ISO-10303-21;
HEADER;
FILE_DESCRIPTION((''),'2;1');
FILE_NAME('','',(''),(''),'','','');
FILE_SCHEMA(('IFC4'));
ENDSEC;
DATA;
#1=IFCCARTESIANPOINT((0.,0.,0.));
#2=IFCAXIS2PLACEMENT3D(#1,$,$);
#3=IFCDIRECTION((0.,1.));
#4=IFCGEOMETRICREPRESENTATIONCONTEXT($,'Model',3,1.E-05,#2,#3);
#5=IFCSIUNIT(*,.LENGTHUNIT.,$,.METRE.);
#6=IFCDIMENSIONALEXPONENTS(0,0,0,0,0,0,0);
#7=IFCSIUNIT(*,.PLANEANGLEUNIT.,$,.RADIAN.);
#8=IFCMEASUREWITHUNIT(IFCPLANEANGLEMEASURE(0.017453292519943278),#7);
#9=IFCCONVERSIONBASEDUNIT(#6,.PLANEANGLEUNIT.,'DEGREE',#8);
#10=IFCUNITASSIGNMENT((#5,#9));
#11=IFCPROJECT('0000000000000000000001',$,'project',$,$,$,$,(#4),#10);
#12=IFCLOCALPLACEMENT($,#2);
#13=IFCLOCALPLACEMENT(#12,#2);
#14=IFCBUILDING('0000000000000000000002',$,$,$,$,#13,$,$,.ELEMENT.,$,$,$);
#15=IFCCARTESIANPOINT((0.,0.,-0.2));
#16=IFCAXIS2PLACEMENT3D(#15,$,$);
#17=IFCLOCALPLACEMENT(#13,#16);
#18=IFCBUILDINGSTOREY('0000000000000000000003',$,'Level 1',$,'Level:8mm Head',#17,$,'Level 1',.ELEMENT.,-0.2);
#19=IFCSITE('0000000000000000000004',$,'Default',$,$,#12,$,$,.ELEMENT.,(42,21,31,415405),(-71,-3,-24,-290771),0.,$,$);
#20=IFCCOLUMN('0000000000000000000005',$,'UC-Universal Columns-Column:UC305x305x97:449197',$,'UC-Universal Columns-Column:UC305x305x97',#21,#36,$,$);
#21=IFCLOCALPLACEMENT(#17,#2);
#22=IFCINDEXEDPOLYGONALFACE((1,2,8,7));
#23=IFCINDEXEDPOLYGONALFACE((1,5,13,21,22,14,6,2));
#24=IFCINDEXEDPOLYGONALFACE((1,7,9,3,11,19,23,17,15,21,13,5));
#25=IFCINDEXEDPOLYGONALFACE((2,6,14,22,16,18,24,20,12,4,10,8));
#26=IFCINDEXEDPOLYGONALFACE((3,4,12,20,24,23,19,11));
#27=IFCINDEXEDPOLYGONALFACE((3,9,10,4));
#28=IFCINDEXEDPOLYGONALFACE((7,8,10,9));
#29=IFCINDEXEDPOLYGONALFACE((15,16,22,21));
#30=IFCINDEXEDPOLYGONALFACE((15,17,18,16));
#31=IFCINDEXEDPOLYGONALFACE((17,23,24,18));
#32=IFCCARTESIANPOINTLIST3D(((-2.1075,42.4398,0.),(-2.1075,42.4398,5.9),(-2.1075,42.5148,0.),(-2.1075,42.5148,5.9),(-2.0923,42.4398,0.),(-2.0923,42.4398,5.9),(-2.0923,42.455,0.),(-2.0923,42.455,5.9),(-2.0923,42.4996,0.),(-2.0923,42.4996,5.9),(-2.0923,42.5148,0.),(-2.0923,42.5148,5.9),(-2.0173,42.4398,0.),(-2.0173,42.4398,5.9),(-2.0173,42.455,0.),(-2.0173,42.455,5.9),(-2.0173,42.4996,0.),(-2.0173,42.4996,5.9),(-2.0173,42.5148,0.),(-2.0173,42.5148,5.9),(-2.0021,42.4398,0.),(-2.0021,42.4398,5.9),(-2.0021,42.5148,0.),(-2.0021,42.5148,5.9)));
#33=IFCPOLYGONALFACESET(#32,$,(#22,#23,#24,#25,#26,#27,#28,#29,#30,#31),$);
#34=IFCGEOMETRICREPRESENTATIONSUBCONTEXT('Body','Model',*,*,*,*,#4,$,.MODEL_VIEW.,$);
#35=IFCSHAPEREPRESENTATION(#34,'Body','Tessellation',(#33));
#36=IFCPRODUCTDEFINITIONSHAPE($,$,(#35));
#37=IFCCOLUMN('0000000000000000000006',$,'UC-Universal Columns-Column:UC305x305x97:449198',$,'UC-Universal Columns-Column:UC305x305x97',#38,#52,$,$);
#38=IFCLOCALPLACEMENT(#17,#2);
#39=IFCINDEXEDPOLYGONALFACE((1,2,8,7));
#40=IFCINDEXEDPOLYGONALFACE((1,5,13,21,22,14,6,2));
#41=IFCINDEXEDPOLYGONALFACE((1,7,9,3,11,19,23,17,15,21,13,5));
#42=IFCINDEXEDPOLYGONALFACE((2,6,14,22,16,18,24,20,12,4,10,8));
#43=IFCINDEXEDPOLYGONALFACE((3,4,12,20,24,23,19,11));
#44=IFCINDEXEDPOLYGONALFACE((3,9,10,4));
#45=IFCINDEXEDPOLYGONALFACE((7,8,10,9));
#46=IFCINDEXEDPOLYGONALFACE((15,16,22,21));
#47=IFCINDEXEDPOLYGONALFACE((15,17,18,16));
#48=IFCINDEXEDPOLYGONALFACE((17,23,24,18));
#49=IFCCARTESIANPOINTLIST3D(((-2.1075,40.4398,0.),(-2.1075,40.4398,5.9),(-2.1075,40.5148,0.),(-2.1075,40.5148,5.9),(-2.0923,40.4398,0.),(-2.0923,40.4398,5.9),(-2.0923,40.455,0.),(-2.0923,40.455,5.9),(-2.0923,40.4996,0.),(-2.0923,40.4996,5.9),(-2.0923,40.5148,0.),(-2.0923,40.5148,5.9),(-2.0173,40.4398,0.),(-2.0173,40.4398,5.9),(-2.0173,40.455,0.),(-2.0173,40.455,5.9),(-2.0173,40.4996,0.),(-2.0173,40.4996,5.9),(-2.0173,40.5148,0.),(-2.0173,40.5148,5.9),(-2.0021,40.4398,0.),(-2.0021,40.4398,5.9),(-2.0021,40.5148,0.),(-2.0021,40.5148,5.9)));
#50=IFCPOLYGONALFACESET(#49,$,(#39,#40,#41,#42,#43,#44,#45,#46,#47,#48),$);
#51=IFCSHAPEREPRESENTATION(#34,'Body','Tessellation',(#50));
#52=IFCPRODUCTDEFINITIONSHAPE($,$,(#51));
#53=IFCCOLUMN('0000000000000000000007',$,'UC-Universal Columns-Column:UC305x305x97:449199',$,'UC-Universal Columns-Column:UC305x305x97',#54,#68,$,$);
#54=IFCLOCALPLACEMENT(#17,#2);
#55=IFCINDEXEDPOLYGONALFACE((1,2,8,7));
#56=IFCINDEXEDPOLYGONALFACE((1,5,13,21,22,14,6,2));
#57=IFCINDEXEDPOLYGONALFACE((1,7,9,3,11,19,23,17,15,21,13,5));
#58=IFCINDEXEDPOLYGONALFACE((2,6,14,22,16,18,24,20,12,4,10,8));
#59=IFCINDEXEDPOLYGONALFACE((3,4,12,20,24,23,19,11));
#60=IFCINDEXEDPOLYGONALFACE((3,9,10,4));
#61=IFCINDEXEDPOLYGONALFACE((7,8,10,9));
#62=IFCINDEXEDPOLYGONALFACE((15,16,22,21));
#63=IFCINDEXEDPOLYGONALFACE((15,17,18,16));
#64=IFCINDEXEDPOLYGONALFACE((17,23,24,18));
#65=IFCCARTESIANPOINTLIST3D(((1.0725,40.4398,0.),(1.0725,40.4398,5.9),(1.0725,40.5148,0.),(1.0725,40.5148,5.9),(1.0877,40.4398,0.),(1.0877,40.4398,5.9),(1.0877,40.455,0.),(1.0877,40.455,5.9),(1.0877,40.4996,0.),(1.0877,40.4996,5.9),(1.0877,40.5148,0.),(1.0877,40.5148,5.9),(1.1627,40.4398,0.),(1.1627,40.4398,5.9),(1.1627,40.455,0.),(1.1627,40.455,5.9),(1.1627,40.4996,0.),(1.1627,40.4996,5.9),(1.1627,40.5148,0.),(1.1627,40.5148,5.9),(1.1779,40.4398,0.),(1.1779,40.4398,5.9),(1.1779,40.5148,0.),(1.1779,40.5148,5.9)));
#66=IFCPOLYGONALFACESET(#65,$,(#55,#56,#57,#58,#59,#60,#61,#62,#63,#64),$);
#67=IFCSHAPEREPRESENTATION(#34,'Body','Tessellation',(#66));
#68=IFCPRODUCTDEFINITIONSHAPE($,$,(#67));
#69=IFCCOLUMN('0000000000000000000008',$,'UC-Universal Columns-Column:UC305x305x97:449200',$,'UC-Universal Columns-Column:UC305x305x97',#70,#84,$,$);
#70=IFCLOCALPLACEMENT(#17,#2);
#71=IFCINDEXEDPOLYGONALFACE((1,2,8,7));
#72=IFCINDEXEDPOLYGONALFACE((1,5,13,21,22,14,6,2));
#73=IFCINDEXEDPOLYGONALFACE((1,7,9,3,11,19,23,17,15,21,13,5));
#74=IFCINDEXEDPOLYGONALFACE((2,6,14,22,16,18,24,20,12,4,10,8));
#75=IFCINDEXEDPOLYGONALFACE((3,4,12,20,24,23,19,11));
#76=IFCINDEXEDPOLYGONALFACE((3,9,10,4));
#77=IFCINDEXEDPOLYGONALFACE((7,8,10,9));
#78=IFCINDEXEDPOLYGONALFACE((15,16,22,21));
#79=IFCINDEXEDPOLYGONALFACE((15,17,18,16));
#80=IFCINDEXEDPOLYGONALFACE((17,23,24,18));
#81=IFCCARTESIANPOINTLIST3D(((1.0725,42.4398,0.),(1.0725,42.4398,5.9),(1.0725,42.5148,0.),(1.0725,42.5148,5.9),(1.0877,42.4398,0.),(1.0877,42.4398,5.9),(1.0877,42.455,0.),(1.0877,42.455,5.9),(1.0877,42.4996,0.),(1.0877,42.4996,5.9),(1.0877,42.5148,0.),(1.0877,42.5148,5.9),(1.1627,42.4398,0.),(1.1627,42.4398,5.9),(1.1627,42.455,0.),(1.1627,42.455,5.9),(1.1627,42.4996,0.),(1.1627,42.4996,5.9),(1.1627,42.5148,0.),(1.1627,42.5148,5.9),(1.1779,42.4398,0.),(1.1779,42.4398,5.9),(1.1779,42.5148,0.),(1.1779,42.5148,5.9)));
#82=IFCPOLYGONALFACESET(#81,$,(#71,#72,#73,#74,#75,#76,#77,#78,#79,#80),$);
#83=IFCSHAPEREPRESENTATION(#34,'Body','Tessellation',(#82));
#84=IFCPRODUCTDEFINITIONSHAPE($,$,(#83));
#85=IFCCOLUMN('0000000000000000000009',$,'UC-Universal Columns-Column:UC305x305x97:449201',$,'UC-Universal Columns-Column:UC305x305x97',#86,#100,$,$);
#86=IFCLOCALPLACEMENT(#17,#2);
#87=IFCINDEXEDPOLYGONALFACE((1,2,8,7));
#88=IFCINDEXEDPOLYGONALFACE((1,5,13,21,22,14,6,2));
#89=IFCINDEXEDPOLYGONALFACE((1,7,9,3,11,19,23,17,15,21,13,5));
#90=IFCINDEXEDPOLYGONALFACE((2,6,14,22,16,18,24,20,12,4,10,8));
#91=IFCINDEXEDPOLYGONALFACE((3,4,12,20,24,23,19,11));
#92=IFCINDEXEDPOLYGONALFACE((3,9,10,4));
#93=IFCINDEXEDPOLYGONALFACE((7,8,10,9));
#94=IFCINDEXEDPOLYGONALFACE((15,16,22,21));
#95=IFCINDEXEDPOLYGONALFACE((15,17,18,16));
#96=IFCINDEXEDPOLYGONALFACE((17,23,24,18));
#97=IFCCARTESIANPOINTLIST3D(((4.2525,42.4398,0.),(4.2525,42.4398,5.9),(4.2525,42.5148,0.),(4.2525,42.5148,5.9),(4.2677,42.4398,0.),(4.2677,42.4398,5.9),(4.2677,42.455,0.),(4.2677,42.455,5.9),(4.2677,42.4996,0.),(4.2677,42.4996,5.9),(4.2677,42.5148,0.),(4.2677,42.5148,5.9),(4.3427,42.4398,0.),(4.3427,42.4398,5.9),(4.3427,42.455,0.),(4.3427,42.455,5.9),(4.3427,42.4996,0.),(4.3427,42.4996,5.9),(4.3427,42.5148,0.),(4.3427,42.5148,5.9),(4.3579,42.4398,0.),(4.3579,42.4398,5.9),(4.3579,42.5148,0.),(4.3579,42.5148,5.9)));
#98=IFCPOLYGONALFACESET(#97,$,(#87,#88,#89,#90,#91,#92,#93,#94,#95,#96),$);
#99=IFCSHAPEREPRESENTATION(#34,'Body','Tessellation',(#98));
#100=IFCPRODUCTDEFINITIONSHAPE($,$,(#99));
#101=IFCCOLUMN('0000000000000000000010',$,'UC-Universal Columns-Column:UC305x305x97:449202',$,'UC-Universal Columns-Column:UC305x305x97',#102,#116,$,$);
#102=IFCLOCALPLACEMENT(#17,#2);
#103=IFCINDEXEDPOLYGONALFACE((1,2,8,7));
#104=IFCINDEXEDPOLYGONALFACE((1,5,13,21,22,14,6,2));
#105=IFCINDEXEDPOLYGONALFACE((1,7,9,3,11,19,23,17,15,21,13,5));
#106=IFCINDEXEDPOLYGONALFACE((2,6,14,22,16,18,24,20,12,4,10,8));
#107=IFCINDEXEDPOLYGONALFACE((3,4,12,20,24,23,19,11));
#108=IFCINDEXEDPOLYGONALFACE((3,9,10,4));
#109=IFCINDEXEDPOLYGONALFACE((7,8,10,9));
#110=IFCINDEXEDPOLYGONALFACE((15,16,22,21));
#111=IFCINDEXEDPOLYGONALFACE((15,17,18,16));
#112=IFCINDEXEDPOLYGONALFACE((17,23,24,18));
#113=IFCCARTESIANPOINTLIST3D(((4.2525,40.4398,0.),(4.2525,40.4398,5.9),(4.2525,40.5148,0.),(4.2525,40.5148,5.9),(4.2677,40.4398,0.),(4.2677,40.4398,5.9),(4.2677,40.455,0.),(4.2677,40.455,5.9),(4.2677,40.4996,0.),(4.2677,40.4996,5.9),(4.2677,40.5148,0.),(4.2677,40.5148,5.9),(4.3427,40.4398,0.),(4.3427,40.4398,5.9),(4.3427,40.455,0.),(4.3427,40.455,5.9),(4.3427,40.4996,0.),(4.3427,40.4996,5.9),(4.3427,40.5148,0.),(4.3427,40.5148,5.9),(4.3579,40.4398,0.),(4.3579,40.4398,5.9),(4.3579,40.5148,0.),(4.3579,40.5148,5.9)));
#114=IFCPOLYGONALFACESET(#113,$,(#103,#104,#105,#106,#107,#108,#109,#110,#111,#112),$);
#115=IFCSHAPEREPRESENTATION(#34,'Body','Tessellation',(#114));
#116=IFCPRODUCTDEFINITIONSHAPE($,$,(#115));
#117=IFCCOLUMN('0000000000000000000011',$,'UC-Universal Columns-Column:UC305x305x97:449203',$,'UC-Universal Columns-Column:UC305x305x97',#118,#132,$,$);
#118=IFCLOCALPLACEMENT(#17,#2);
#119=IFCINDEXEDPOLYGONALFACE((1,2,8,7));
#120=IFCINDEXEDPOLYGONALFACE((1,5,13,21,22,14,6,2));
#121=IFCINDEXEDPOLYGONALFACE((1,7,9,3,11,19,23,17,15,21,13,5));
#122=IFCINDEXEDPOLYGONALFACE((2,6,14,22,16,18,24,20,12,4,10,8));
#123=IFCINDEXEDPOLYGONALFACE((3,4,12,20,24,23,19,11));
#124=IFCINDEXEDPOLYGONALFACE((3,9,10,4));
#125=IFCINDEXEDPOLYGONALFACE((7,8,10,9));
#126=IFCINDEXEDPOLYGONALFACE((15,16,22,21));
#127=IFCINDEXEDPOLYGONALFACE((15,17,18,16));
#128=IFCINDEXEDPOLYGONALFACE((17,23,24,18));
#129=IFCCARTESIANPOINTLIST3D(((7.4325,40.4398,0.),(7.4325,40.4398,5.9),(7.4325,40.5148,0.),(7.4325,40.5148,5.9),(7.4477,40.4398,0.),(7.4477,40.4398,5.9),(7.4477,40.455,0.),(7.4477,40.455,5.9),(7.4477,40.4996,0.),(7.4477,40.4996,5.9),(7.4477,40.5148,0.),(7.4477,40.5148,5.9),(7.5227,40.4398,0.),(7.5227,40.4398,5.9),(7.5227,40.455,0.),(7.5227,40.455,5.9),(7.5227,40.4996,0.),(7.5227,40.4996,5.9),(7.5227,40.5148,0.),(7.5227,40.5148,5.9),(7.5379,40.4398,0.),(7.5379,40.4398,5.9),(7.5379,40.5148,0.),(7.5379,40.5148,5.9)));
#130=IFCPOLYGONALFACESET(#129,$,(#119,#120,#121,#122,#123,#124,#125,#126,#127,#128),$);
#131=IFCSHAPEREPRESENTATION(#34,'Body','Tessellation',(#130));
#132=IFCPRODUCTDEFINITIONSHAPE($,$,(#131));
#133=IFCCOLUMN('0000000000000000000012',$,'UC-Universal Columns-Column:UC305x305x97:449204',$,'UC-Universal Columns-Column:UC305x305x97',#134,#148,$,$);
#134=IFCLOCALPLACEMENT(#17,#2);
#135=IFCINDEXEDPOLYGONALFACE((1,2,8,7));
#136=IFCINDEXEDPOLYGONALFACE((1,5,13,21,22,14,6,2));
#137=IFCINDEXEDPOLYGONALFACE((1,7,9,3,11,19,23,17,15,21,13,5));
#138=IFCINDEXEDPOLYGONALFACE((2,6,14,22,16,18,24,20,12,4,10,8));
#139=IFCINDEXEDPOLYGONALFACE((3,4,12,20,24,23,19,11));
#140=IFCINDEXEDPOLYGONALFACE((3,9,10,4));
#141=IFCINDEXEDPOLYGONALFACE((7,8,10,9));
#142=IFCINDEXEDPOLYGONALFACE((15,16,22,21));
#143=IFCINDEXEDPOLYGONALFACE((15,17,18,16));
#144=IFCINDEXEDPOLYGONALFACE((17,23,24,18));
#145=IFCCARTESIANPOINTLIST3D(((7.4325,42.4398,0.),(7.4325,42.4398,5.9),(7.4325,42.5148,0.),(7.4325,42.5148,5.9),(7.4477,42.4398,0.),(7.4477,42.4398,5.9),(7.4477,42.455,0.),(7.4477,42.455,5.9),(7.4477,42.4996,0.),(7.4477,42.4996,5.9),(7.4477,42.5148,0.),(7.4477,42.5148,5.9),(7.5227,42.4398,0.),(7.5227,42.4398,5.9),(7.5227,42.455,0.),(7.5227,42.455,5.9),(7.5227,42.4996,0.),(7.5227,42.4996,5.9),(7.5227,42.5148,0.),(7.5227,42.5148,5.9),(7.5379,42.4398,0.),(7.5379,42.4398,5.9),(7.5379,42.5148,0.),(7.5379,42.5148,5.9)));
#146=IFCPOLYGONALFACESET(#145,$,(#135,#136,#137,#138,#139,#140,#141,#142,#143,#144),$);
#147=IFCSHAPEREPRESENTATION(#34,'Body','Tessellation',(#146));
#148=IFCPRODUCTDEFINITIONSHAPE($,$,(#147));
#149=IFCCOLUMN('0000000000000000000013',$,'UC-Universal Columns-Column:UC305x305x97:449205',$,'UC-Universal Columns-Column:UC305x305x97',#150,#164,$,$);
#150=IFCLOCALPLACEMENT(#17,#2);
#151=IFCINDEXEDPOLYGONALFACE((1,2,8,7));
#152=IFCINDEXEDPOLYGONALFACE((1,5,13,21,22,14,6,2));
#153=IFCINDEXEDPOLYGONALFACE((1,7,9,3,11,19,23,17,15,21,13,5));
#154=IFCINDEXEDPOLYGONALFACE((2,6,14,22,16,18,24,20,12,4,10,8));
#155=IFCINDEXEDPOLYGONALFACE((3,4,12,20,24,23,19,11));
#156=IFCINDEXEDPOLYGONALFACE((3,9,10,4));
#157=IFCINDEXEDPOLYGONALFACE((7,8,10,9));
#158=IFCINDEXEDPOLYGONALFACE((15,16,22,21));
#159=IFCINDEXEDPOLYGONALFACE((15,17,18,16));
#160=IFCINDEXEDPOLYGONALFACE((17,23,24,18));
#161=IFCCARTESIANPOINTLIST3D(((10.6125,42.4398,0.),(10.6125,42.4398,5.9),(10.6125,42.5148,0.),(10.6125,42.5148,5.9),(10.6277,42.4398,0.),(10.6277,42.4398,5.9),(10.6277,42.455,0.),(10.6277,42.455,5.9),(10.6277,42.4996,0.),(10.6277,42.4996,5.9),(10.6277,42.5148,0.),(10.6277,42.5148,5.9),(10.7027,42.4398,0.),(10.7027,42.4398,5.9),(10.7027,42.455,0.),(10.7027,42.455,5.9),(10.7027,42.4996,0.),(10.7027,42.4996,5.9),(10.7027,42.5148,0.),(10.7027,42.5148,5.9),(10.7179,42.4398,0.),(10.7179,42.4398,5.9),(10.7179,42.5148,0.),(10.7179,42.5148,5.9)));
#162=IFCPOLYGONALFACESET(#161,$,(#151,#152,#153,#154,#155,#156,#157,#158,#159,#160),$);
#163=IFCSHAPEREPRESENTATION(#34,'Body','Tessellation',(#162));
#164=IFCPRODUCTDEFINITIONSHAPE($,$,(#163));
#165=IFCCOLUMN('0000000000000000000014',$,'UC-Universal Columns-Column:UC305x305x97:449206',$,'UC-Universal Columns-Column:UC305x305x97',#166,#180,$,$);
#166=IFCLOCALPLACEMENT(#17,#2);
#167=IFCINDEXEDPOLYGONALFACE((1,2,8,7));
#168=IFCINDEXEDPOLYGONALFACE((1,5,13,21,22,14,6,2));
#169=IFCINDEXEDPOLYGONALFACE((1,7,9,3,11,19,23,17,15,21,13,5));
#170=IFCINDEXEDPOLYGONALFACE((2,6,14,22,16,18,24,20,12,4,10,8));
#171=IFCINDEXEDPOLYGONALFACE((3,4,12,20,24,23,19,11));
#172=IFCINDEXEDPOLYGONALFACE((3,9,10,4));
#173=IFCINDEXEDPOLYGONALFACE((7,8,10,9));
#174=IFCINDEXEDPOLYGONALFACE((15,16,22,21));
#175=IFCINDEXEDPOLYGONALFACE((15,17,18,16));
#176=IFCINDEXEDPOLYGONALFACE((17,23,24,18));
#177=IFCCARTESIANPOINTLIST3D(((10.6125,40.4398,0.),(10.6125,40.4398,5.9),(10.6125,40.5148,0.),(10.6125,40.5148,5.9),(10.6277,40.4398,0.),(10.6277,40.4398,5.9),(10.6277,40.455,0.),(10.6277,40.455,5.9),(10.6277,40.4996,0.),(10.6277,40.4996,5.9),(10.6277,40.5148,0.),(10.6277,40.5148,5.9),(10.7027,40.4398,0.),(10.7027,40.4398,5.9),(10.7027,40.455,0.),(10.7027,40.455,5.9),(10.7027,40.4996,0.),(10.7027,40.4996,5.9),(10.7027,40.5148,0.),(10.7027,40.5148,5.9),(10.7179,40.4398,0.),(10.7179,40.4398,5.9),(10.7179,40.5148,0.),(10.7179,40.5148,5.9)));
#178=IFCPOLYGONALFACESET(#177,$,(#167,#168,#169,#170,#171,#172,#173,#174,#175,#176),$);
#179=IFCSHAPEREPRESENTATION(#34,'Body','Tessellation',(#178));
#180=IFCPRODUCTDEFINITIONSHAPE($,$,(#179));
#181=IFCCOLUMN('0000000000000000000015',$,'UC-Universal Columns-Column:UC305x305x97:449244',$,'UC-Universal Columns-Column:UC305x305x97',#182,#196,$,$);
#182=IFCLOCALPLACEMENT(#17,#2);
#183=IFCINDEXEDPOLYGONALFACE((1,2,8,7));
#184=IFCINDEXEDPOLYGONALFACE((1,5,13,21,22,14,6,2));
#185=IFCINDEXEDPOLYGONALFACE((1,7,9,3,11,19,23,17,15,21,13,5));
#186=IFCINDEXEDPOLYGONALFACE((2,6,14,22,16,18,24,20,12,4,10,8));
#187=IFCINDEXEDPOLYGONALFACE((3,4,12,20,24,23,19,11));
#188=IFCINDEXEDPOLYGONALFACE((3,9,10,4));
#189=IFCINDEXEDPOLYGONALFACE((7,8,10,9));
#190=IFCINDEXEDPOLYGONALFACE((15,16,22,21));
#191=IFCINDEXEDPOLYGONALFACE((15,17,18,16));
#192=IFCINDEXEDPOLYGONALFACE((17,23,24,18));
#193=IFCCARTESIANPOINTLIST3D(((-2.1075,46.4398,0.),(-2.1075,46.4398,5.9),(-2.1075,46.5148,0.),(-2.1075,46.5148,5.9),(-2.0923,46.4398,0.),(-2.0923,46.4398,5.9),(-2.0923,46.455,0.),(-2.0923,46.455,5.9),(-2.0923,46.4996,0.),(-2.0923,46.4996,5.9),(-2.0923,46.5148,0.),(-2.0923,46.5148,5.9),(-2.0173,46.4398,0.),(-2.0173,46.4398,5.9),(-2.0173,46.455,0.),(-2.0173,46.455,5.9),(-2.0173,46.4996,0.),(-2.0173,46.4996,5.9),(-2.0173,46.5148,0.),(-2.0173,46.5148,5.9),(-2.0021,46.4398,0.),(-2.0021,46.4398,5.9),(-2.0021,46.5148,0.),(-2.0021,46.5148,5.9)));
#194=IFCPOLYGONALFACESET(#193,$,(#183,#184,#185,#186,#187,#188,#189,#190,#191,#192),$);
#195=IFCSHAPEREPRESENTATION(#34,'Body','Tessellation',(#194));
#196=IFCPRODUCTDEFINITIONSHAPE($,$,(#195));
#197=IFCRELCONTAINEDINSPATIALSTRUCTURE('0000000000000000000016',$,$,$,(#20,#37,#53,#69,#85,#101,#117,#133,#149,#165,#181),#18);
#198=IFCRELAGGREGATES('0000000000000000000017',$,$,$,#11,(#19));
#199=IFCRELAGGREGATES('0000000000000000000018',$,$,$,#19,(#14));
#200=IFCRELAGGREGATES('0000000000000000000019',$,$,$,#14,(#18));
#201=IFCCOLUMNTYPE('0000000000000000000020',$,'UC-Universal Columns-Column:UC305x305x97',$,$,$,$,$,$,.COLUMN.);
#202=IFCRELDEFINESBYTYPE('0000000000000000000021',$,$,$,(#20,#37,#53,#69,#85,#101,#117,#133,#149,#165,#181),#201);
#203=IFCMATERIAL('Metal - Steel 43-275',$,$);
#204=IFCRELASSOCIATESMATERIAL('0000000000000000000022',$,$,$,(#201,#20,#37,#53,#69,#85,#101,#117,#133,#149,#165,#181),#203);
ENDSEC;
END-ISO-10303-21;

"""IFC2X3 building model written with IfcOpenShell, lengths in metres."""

from ifc_helpers import new_model, entity, si_unit, converted_unit, direction, frame, frame_2d, origin, place, context, subcontext, project, spatial, polyline, circle_curve, parameter, trimmed, segment, composite_curve, outline, extrude, source, transform, mapped, material, type_object, type_shapes, element, save


model = new_model("IFC2X3")

# Units and contexts
model_context = context("Model", 3, precision=1e-05, world=origin(), true_north=direction((0.0, 1.0)))
body_context = subcontext(model_context, "Body", "Model", "MODEL_VIEW")
ifc_project = project(units=[si_unit("LENGTHUNIT", "METRE"), converted_unit("PLANEANGLEUNIT", "DEGREE", entity("IfcPlaneAngleMeasure", 0.017453292519943278), si_unit("PLANEANGLEUNIT", "RADIAN"), dimensions=[0, 0, 0, 0, 0, 0, 0])], contexts=[model_context])

# Site, building, storey
site_placement = place(None, origin())
site = spatial("IfcSite", under=ifc_project, at=site_placement, Name="Default", CompositionType="ELEMENT", RefLatitude=(42, 21, 31, 415405), RefLongitude=(-71, -3, -24, -290771), RefElevation=0.0)
building_placement = place(site_placement, origin())
building = spatial("IfcBuilding", under=site, at=building_placement, CompositionType="ELEMENT")
storey_placement = place(building_placement, frame((0.0, 0.0, -0.2)))
storey = spatial("IfcBuildingStorey", under=building, at=storey_placement, Name="Level 1", ObjectType="Level:8mm Head", LongName="Level 1", CompositionType="ELEMENT", Elevation=-0.2)

# Columns
ifc_material = material(Name="Metal - Steel 43-275")
column_type = type_object("IfcColumnType", Name="UC-Universal Columns-Column:UC305x305x97", PredefinedType="COLUMN", material=ifc_material)
shared_shape = source(origin(), body_context, "Body", "SweptSolid", [
    extrude(outline(composite_curve([segment(polyline([(-0.0375, -0.0375), (0.0375, -0.0375)]), True, "CONTINUOUS"), segment(polyline([(0.0375, -0.0375), (0.0527, -0.0375)]), True, "CONTINUOUS"), segment(trimmed(circle_curve(frame_2d((0.0527, -0.0223), x_axis=(-1.0, 0.0)), 0.0152), [parameter(0.0)], [parameter(90.0)], True, "PARAMETER"), False, "CONTINUOUS"), segment(polyline([(0.0375, -0.0223), (0.0375, 0.0223)]), True, "CONTINUOUS"), segment(trimmed(circle_curve(frame_2d((0.0527, 0.0223), x_axis=(-1.0, 0.0)), 0.0152), [parameter(270.0)], [parameter(0.0)], True, "PARAMETER"), False, "CONTINUOUS"), segment(polyline([(0.0527, 0.0375), (0.0375, 0.0375)]), True, "CONTINUOUS"), segment(polyline([(0.0375, 0.0375), (-0.0375, 0.0375)]), True, "CONTINUOUS"), segment(polyline([(-0.0375, 0.0375), (-0.0527, 0.0375)]), True, "CONTINUOUS"), segment(trimmed(circle_curve(frame_2d((-0.0527, 0.0223), x_axis=(-1.0, 0.0)), 0.0152), [parameter(180.0)], [parameter(270.0)], True, "PARAMETER"), False, "CONTINUOUS"), segment(polyline([(-0.0375, 0.0223), (-0.0375, -0.0223)]), True, "CONTINUOUS"), segment(trimmed(circle_curve(frame_2d((-0.0527, -0.0223), x_axis=(-1.0, 0.0)), 0.0152), [parameter(90.0)], [parameter(180.0)], True, "PARAMETER"), False, "CONTINUOUS"), segment(polyline([(-0.0527, -0.0375), (-0.0375, -0.0375)]), True, "CONTINUOUS")], self_intersect=False)), frame((0.0, 0.0, -0.2), z_axis=(0.0, 0.0, 1.0), x_axis=(-1.0, 0.0, 0.0)), (0.0, 0.0, 1.0), 5.9),
])
type_shapes(column_type, [shared_shape])
for number, where, z_axis, x_axis, name in (
    (1, (-2.0548, 42.4773, 0.2), (0.0, 0.0, 1.0), (-1.0, 0.0, 0.0), "UC-Universal Columns-Column:UC305x305x97:449197"),
    (2, (-2.0548, 40.4773, 0.2), (0.0, 0.0, 1.0), (-1.0, 0.0, 0.0), "UC-Universal Columns-Column:UC305x305x97:449198"),
    (3, (1.1252, 40.4773, 0.2), (0.0, 0.0, 1.0), (-1.0, 0.0, 0.0), "UC-Universal Columns-Column:UC305x305x97:449199"),
    (4, (1.1252, 42.4773, 0.2), (0.0, 0.0, 1.0), (-1.0, 0.0, 0.0), "UC-Universal Columns-Column:UC305x305x97:449200"),
    (5, (4.3052, 42.4773, 0.2), (0.0, 0.0, 1.0), (-1.0, 0.0, 0.0), "UC-Universal Columns-Column:UC305x305x97:449201"),
    (6, (4.3052, 40.4773, 0.2), (0.0, 0.0, 1.0), (-1.0, 0.0, 0.0), "UC-Universal Columns-Column:UC305x305x97:449202"),
    (7, (7.4852, 40.4773, 0.2), (0.0, 0.0, 1.0), (-1.0, 0.0, 0.0), "UC-Universal Columns-Column:UC305x305x97:449203"),
    (8, (7.4852, 42.4773, 0.2), (0.0, 0.0, 1.0), (-1.0, 0.0, 0.0), "UC-Universal Columns-Column:UC305x305x97:449204"),
    (9, (10.6652, 42.4773, 0.2), (0.0, 0.0, 1.0), (-1.0, 0.0, 0.0), "UC-Universal Columns-Column:UC305x305x97:449205"),
    (10, (10.6652, 40.4773, 0.2), (0.0, 0.0, 1.0), (-1.0, 0.0, 0.0), "UC-Universal Columns-Column:UC305x305x97:449206"),
    (11, (-2.0548, 46.4773, 0.2), (0.0, 0.0, 1.0), (-1.0, 0.0, 0.0), "UC-Universal Columns-Column:UC305x305x97:449244"),
):
    element("IfcColumn", number, at=place(storey_placement, frame(where, z_axis=z_axis, x_axis=x_axis)), inside=storey, type_object=column_type, material=ifc_material, Name=name, ObjectType="UC-Universal Columns-Column:UC305x305x97", context=body_context, shape_type="MappedRepresentation", body=[
        mapped(shared_shape, transform((0.0, 0.0, 0.0), scale=1.0)),
    ])

save(model, "model.ifc")
